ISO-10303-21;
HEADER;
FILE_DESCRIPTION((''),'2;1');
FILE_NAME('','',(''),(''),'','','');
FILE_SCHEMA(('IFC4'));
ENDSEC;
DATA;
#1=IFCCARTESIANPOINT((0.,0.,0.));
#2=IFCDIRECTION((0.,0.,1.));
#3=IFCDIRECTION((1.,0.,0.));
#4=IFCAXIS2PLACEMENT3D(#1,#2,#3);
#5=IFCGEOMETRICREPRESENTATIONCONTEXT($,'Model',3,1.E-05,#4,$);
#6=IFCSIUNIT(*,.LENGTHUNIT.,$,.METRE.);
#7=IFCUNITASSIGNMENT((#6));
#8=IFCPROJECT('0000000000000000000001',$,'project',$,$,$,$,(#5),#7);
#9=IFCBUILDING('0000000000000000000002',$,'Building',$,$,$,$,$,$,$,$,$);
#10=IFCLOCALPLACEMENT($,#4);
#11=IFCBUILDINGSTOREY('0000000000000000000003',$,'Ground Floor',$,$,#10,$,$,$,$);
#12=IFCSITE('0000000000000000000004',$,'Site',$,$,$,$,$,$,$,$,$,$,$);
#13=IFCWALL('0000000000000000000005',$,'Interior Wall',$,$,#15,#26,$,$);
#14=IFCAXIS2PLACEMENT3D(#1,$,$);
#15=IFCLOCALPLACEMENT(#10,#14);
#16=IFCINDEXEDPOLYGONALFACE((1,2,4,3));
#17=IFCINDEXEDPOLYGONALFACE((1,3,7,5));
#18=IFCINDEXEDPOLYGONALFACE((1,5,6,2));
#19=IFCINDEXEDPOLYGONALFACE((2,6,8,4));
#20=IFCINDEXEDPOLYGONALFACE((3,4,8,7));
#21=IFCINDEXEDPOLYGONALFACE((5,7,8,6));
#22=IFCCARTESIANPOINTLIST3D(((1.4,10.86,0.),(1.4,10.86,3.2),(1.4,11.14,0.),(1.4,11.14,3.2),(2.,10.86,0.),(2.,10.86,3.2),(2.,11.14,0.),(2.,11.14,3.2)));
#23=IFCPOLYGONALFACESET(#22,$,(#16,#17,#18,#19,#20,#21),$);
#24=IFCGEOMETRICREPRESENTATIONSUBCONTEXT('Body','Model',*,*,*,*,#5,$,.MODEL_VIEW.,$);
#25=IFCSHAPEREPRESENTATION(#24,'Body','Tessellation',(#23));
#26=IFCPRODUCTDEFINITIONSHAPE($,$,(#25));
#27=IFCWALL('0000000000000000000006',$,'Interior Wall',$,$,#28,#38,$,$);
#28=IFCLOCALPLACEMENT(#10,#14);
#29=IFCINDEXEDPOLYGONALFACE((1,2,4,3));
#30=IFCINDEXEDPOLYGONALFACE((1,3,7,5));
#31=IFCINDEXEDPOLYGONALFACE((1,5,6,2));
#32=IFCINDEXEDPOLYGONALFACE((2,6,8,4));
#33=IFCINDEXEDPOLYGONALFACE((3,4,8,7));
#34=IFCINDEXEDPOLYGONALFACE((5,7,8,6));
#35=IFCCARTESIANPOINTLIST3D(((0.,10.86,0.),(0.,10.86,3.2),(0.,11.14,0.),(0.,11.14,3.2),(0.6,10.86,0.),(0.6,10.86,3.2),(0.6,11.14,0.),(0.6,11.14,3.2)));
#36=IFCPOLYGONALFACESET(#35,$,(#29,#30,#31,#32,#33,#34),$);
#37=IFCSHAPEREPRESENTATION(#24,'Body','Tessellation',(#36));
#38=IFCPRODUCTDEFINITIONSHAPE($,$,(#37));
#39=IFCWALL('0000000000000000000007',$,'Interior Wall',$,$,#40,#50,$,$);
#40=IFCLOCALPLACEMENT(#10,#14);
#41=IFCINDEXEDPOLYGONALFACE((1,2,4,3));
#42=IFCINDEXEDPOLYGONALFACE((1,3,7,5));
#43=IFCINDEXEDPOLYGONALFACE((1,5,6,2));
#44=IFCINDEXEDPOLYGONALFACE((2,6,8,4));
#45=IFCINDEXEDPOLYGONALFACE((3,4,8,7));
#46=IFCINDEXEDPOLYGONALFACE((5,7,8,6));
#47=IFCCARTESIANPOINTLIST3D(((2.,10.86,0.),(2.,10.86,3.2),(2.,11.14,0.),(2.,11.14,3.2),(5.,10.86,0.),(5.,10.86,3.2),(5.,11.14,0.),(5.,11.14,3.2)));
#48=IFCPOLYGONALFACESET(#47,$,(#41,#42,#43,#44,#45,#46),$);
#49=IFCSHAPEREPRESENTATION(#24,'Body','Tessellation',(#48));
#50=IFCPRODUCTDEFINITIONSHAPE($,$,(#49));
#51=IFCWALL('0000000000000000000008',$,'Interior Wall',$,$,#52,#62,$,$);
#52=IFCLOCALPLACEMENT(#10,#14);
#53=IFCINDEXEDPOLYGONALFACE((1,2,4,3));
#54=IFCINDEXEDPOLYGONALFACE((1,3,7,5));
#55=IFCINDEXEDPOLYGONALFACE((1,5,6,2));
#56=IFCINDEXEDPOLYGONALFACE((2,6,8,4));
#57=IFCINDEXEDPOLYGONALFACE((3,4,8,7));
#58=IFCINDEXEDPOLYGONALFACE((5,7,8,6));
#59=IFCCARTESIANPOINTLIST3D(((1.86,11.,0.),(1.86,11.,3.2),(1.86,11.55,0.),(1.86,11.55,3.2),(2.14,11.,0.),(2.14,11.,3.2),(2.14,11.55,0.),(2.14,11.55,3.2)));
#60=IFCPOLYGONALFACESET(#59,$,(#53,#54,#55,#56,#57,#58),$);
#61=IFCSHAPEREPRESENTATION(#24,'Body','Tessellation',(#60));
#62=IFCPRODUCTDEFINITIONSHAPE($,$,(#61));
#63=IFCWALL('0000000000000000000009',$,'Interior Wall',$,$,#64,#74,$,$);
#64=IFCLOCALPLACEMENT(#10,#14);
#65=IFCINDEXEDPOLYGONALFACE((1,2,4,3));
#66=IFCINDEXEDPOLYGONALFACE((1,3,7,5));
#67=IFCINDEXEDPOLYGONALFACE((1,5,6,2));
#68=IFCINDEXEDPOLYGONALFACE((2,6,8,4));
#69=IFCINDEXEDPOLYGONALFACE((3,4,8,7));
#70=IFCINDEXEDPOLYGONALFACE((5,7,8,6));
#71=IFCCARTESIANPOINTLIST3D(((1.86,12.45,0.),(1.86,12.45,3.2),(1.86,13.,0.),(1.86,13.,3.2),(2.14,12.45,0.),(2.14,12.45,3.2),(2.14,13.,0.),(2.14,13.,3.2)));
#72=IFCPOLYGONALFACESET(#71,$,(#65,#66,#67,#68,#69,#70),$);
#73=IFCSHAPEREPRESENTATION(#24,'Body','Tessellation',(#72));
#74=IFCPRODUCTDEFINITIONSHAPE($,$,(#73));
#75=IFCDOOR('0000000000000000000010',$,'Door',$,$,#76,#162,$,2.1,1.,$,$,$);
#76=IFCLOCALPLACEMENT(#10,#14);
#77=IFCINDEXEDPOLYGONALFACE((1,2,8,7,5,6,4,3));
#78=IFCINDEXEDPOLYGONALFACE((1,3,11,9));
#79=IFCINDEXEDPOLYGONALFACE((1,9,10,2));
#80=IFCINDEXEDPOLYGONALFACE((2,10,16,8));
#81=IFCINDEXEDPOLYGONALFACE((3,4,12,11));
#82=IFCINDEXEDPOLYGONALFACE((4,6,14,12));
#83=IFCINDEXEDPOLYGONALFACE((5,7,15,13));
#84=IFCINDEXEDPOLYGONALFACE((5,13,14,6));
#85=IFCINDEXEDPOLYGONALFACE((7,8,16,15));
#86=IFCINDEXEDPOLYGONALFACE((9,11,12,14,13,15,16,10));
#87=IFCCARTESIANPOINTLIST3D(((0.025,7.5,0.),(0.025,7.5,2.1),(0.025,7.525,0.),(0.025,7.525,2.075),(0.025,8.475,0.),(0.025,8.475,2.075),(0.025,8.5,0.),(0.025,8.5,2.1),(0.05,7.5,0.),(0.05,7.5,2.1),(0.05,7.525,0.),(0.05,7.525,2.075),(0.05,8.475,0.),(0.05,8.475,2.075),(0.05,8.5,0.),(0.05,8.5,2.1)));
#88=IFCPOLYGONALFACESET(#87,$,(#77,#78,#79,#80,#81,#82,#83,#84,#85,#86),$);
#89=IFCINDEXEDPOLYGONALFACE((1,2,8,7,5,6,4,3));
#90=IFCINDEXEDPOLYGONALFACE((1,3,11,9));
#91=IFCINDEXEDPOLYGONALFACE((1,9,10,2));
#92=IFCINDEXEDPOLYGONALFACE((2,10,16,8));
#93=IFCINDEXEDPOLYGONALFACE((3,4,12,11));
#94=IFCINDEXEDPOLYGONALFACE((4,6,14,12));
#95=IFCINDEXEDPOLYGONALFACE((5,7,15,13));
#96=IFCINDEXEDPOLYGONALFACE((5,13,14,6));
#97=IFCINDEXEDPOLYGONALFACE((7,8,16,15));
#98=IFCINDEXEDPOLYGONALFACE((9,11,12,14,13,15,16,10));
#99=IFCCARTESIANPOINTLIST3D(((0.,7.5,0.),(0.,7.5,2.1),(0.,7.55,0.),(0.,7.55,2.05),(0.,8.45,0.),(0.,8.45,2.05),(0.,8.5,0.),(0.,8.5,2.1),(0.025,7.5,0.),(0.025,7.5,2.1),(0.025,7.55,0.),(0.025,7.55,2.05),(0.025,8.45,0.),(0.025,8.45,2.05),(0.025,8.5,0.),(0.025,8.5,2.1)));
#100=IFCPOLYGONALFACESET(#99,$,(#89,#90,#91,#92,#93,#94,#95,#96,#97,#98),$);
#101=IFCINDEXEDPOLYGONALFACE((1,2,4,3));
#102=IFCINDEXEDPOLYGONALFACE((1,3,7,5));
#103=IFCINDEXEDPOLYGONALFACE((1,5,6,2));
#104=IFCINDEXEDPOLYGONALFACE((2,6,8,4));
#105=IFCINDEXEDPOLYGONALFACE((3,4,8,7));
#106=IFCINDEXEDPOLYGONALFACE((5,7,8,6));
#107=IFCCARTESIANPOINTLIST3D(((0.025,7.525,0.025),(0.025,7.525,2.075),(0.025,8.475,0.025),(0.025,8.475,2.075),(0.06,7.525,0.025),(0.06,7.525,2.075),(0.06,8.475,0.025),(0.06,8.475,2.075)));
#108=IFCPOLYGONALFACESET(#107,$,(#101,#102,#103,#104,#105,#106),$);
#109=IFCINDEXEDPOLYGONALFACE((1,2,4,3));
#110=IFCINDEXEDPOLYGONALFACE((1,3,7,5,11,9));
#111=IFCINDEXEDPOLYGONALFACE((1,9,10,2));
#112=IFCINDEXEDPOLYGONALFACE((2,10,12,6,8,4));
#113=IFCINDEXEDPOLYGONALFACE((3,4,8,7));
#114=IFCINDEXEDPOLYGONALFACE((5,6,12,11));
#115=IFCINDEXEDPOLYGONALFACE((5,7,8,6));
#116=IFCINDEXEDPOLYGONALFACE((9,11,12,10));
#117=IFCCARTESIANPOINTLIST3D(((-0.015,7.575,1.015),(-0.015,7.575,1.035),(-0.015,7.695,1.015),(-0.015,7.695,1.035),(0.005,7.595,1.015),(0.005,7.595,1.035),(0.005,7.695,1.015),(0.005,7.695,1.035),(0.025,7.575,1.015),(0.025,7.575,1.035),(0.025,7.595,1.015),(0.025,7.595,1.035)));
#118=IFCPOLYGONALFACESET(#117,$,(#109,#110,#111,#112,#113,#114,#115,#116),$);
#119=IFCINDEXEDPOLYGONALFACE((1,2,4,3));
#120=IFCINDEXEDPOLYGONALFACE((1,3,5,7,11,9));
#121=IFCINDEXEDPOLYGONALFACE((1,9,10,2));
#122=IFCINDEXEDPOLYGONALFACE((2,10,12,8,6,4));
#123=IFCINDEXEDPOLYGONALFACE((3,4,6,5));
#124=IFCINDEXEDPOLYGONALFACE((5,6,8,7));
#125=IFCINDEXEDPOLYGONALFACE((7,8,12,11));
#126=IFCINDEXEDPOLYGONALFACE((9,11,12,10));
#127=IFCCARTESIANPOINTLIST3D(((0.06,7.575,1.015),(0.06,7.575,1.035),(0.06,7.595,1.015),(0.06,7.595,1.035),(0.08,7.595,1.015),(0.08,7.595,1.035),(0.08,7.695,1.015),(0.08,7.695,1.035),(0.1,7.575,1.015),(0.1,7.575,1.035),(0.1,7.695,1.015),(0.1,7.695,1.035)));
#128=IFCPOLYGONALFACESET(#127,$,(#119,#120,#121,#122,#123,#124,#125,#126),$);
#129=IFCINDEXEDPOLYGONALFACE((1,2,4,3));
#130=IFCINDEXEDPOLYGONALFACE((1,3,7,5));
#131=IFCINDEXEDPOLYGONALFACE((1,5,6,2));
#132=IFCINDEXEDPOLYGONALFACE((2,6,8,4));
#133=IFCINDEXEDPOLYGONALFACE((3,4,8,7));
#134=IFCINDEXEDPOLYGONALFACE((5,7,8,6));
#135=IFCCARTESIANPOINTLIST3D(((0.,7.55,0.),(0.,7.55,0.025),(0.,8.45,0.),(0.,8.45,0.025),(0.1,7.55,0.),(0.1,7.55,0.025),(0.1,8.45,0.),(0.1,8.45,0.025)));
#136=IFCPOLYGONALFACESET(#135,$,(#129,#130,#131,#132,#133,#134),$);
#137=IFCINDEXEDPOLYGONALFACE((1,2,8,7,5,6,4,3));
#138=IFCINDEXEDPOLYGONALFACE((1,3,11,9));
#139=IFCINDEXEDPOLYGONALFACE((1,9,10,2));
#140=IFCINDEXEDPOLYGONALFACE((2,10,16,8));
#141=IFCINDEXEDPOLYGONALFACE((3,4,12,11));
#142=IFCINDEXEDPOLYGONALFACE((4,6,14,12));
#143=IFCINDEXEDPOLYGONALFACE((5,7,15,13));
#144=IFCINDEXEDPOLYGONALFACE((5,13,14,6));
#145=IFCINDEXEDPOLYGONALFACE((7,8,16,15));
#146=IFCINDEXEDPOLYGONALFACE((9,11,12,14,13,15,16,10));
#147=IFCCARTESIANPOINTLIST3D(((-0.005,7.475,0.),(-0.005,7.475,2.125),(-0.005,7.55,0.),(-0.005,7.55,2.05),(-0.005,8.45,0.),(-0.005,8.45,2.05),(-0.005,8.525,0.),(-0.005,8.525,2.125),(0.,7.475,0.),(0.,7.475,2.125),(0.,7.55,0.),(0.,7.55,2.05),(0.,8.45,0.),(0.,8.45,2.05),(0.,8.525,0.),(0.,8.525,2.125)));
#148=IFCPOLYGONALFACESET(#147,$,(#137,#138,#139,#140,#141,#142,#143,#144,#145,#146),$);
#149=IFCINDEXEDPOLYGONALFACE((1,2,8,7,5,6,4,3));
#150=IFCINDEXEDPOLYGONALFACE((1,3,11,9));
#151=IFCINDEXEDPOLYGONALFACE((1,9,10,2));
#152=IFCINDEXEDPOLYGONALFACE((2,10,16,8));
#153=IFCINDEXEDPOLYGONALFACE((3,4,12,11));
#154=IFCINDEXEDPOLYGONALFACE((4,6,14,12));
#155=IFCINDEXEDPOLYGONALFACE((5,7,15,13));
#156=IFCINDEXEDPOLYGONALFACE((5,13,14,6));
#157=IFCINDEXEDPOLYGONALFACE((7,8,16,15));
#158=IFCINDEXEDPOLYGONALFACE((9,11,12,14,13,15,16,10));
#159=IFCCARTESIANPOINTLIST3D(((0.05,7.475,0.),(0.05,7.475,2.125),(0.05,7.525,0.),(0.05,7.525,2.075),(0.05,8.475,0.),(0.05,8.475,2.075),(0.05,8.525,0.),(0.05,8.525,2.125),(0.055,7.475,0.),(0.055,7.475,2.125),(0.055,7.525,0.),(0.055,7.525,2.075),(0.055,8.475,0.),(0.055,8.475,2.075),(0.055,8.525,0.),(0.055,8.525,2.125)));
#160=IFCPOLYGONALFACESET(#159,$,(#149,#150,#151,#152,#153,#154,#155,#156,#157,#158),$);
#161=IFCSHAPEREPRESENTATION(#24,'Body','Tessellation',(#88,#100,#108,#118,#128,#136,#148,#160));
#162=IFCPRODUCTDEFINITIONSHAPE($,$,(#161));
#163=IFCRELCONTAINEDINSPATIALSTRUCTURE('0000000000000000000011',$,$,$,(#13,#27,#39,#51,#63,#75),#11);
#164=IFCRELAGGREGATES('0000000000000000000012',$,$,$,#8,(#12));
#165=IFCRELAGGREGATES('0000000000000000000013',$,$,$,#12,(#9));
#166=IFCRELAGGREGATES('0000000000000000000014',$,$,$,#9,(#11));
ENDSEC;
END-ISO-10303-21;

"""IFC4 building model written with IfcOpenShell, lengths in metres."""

from ifc_helpers import new_model, si_unit, frame, origin_with_axes, place, context, subcontext, project, spatial, line, indexed_curve, outline, extrude, element, save


model = new_model("IFC4")

# Units and contexts
model_context = context("Model", 3, precision=1e-05, world=origin_with_axes())
body_context = subcontext(model_context, "Body", "Model", "MODEL_VIEW")
ifc_project = project(units=[si_unit("LENGTHUNIT", "METRE")], contexts=[model_context])

# Site, building, storey
site = spatial("IfcSite", under=ifc_project, Name="Site")
building = spatial("IfcBuilding", under=site, Name="Building")
storey_placement = place(None, origin_with_axes())
storey = spatial("IfcBuildingStorey", under=building, at=storey_placement, Name="Ground Floor")

# Walls
for number, where, z_axis, x_axis, name in (
    (1, (2.0, 11.0, 0.0), (0.0, 0.0, 1.0), (-1.0, 0.0, 0.0), "Interior Wall"),
    (2, (0.6, 11.0, 0.0), (0.0, 0.0, 1.0), (-1.0, 0.0, 0.0), "Interior Wall"),
):
    element("IfcWall", number, at=place(storey_placement, frame(where, z_axis=z_axis, x_axis=x_axis)), inside=storey, Name=name, context=body_context, shape_type="SweptSolid", body=[
        extrude(outline(indexed_curve([(0.0, 0.0), (0.0, 0.28), (0.6, 0.28), (0.6, 0.0), (0.0, 0.0)], self_intersect=False)), frame((0.0, -0.14, 0.0), z_axis=(0.0, 0.0, 1.0), x_axis=(1.0, 0.0, 0.0)), (0.0, 0.0, 1.0), 3.2),
    ])
wall_1_placement = place(storey_placement, frame((5.0, 11.0, 0.0), z_axis=(0.0, 0.0, 1.0), x_axis=(-1.0, 0.0, 0.0)))
element("IfcWall", 3, at=wall_1_placement, inside=storey, Name="Interior Wall", context=body_context, shape_type="SweptSolid", body=[
    extrude(outline(indexed_curve([(0.0, 0.0), (0.0, 0.28), (3.0, 0.28), (3.0, 0.0), (0.0, 0.0)], self_intersect=False)), frame((0.0, -0.14, 0.0), z_axis=(0.0, 0.0, 1.0), x_axis=(1.0, 0.0, 0.0)), (0.0, 0.0, 1.0), 3.2),
])
for number, where, z_axis, x_axis, name in (
    (4, (2.0, 11.0, 0.0), (0.0, 0.0, 1.0), (0.0, 1.0, 0.0), "Interior Wall"),
    (5, (2.0, 12.45, 0.0), (0.0, 0.0, 1.0), (0.0, 1.0, 0.0), "Interior Wall"),
):
    element("IfcWall", number, at=place(storey_placement, frame(where, z_axis=z_axis, x_axis=x_axis)), inside=storey, Name=name, context=body_context, shape_type="SweptSolid", body=[
        extrude(outline(indexed_curve([(0.0, 0.0), (0.0, 0.28), (0.55, 0.28), (0.55, 0.0), (0.0, 0.0)], self_intersect=False)), frame((0.0, -0.14, 0.0), z_axis=(0.0, 0.0, 1.0), x_axis=(1.0, 0.0, 0.0)), (0.0, 0.0, 1.0), 3.2),
    ])

# Door
door_1_placement = place(storey_placement, frame((0.0, 8.5, 0.0), z_axis=(0.0, 0.0, 1.0), x_axis=(0.0, -1.0, 0.0)))
element("IfcDoor", 6, at=door_1_placement, inside=storey, Name="Door", OverallHeight=2.1, OverallWidth=1.0, context=body_context, shape_type="SweptSolid", body=[
    extrude(outline(indexed_curve([(0.0, 0.0), (0.0, 2.1), (1.0, 2.1), (1.0, 0.0), (0.975, 0.0), (0.975, 2.075), (0.025, 2.075), (0.025, 0.0)], segments=[line(1, 2, 3, 4, 5, 6, 7, 8, 1)])), frame((0.0, 0.025, 0.0), z_axis=(0.0, -1.0, 0.0), x_axis=(1.0, 0.0, 0.0)), (0.0, 0.0, -1.0), 0.025),
    extrude(outline(indexed_curve([(0.0, 0.0), (0.0, 2.1), (1.0, 2.1), (1.0, 0.0), (0.95, 0.0), (0.95, 2.05), (0.05, 2.05), (0.05, 0.0)], segments=[line(1, 2, 3, 4, 5, 6, 7, 8, 1)])), frame((0.0, 0.0, 0.0), z_axis=(0.0, -1.0, 0.0), x_axis=(1.0, 0.0, 0.0)), (0.0, 0.0, -1.0), 0.025),
    extrude(outline(indexed_curve([(0.0, 0.0), (0.95, 0.0), (0.95, 0.035), (0.0, 0.035)], segments=[line(1, 2, 3, 4, 1)])), frame((0.025, 0.025, 0.025), z_axis=(0.0, 0.0, 1.0), x_axis=(1.0, 0.0, 0.0)), (0.0, 0.0, 1.0), 2.05),
    extrude(outline(indexed_curve([(0.0, 0.0), (0.0, -0.04), (-0.12, -0.04), (-0.12, -0.02), (-0.02, -0.02), (-0.02, 0.0)], segments=[line(1, 2, 3, 4, 5, 6, 1)])), frame((0.925, 0.025, 1.015), z_axis=(0.0, 0.0, 1.0), x_axis=(1.0, 0.0, 0.0)), (0.0, 0.0, 1.0), 0.02),
    extrude(outline(indexed_curve([(0.0, 0.0), (0.0, 0.04), (-0.12, 0.04), (-0.12, 0.02), (-0.02, 0.02), (-0.02, 0.0)], segments=[line(1, 2, 3, 4, 5, 6, 1)])), frame((0.925, 0.06, 1.015), z_axis=(0.0, 0.0, 1.0), x_axis=(1.0, 0.0, 0.0)), (0.0, 0.0, 1.0), 0.02),
    extrude(outline(indexed_curve([(0.0, 0.0), (0.9, 0.0), (0.9, 0.1), (0.0, 0.1)], segments=[line(1, 2, 3, 4, 1)])), frame((0.05, 0.0, 0.0), z_axis=(0.0, 0.0, 1.0), x_axis=(1.0, 0.0, 0.0)), (0.0, 0.0, 1.0), 0.025),
    extrude(outline(indexed_curve([(0.0, 0.0), (0.0, 2.125), (1.05, 2.125), (1.05, 0.0), (0.975, 0.0), (0.975, 2.05), (0.075, 2.05), (0.075, 0.0)], segments=[line(1, 2, 3, 4, 5, 6, 7, 8, 1)])), frame((-0.025, -0.005, 0.0), z_axis=(0.0, -1.0, 0.0), x_axis=(1.0, 0.0, 0.0)), (0.0, 0.0, -1.0), 0.005),
    extrude(outline(indexed_curve([(0.0, 0.0), (0.0, 2.125), (1.05, 2.125), (1.05, 0.0), (1.0, 0.0), (1.0, 2.075), (0.05, 2.075), (0.05, 0.0)], segments=[line(1, 2, 3, 4, 5, 6, 7, 8, 1)])), frame((-0.025, 0.05, 0.0), z_axis=(0.0, -1.0, 0.0), x_axis=(1.0, 0.0, 0.0)), (0.0, 0.0, -1.0), 0.005),
])

save(model, "model.ifc")
